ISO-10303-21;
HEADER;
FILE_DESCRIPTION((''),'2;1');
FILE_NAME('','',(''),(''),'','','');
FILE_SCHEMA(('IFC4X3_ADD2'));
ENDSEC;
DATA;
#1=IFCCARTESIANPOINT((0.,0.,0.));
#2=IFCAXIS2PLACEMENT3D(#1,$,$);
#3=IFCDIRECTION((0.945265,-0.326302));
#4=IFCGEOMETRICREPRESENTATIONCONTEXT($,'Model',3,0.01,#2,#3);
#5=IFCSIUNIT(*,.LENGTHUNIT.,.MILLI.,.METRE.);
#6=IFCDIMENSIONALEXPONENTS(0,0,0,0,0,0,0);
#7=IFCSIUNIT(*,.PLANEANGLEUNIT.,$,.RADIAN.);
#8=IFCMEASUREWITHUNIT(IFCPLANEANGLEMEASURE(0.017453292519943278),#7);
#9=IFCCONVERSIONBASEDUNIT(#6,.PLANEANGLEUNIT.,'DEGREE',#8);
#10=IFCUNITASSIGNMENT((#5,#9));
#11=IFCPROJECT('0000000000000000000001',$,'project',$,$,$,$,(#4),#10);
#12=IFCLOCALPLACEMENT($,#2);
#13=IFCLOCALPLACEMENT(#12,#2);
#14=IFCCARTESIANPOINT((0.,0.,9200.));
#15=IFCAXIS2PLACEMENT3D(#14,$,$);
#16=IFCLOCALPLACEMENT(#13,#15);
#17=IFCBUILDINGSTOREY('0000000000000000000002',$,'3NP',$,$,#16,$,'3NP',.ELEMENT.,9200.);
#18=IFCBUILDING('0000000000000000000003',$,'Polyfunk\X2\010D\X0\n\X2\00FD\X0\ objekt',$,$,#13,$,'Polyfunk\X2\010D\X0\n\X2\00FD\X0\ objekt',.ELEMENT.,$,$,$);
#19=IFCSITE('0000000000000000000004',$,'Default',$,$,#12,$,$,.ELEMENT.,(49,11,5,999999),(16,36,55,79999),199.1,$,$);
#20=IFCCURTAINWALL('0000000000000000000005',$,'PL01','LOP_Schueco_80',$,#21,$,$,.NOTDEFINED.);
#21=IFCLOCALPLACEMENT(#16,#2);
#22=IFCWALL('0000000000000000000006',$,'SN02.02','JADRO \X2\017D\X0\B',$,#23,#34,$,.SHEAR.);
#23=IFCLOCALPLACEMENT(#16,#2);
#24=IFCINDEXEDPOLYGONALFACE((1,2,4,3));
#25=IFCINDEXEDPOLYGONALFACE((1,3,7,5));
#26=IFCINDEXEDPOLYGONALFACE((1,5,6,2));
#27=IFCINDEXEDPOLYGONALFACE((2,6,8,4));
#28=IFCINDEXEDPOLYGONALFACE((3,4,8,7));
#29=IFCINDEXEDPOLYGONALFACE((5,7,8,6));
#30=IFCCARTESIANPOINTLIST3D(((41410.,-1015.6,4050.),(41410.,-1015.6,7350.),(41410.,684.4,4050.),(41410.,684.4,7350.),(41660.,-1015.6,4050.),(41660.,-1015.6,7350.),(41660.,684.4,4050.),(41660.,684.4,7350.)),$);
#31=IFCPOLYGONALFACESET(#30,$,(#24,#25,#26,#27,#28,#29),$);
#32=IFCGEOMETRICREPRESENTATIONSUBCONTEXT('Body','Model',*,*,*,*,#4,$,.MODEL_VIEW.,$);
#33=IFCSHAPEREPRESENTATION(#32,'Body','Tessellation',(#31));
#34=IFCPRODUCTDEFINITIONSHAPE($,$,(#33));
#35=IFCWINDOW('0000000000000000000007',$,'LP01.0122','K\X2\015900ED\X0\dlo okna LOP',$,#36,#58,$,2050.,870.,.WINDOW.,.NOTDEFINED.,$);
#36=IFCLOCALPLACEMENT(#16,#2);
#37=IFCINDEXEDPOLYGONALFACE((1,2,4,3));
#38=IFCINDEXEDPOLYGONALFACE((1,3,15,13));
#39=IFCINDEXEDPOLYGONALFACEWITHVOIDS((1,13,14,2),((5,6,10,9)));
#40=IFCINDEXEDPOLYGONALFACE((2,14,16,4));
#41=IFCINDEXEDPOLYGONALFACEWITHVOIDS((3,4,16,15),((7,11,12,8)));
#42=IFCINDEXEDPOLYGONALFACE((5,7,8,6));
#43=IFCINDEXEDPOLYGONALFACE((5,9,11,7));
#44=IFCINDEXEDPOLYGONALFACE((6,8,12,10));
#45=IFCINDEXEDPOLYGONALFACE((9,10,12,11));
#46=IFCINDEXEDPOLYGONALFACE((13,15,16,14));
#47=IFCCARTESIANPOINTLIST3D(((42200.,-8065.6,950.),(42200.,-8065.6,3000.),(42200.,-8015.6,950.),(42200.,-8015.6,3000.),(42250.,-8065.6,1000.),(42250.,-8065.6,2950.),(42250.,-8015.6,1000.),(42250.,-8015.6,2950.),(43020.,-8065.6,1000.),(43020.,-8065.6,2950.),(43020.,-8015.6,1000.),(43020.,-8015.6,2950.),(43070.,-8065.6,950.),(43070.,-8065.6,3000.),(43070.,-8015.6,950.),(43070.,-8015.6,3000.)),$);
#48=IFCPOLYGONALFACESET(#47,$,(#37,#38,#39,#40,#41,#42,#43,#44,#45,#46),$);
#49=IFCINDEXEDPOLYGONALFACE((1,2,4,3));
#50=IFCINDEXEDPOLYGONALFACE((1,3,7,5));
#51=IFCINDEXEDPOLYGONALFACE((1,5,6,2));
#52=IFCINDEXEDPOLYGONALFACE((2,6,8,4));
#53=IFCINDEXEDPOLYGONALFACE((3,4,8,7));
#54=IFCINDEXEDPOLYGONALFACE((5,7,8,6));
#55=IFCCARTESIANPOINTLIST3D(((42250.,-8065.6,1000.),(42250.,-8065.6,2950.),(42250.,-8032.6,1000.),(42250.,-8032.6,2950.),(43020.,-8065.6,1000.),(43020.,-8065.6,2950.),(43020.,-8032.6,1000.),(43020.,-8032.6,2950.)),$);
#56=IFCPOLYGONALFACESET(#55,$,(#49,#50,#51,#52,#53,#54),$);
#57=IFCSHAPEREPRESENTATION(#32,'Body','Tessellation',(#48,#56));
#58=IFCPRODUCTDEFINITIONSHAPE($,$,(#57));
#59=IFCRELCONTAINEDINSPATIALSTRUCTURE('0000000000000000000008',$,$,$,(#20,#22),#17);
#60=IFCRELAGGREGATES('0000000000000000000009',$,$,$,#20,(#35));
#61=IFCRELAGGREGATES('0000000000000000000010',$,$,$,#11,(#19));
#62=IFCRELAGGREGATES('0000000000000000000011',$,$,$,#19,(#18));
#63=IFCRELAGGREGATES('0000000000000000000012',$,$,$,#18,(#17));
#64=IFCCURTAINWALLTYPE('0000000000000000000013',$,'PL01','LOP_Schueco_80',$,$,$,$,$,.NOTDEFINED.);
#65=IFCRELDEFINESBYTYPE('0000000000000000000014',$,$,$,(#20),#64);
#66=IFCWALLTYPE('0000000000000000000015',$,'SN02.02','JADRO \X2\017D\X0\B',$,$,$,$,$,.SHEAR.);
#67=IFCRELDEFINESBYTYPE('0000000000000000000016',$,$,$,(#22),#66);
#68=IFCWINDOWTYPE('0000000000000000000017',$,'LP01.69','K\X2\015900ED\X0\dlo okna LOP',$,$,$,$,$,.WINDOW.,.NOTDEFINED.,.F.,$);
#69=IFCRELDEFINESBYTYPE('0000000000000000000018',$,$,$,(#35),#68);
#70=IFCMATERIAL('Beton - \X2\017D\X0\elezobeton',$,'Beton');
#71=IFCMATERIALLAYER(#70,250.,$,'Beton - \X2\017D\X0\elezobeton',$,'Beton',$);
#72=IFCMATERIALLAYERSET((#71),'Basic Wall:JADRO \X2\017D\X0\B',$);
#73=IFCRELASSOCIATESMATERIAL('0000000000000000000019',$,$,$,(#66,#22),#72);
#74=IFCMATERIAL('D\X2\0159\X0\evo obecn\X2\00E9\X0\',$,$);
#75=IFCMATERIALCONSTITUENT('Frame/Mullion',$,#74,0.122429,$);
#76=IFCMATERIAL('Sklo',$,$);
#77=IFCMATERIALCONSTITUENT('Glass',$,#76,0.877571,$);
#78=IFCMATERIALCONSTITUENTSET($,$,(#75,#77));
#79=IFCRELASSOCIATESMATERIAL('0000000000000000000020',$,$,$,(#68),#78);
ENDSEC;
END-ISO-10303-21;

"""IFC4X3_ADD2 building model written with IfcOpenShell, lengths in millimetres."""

from ifc_helpers import new_model, entity, si_unit, converted_unit, direction, frame, frame_2d, origin, place, context, subcontext, project, spatial, polyline, rectangle, outline, extrude, clip, bounded_halfspace, source, transform, mapped, material, layer, layer_set, constituent, constituent_set, type_object, type_shapes, element, aggregate, save


model = new_model("IFC4X3_ADD2")

# Units and contexts
model_context = context("Model", 3, precision=0.01, world=origin(), true_north=direction((0.945265, -0.326302)))
body_context = subcontext(model_context, "Body", "Model", "MODEL_VIEW")
ifc_project = project(units=[si_unit("LENGTHUNIT", "METRE", prefix="MILLI"), converted_unit("PLANEANGLEUNIT", "DEGREE", entity("IfcPlaneAngleMeasure", 0.017453292519943278), si_unit("PLANEANGLEUNIT", "RADIAN"), dimensions=[0, 0, 0, 0, 0, 0, 0])], contexts=[model_context])

# Site, building, storey
site_placement = place(None, origin())
site = spatial("IfcSite", under=ifc_project, at=site_placement, Name="Default", CompositionType="ELEMENT", RefLatitude=(49, 11, 5, 999999), RefLongitude=(16, 36, 55, 79999), RefElevation=199.1)
building_placement = place(site_placement, origin())
building = spatial("IfcBuilding", under=site, at=building_placement, Name="Polyfunkčný objekt", LongName="Polyfunkčný objekt", CompositionType="ELEMENT")
storey_placement = place(building_placement, frame((0.0, 0.0, 9200.0)))
storey = spatial("IfcBuildingStorey", under=building, at=storey_placement, Name="3NP", LongName="3NP", CompositionType="ELEMENT", Elevation=9200.0)

# Curtain wall
curtain_wall_type = type_object("IfcCurtainWallType", Name="PL01", Description="LOP_Schueco_80", PredefinedType="NOTDEFINED")
curtain_wall_placement = place(storey_placement, frame((0.0, 0.0, -9200.0)))
curtain_wall = element("IfcCurtainWall", 1, at=curtain_wall_placement, inside=storey, type_object=curtain_wall_type, Name="PL01", Description="LOP_Schueco_80", PredefinedType="NOTDEFINED")
ifc_material_1 = material(Name="Sklo")

# Wall
ifc_material_2 = material(Name="Beton - Železobeton", Category="Beton")
ifc_layer_1 = layer(ifc_material_2, 250.0, Name="Beton - Železobeton", Category="Beton")
ifc_layer_set_1 = layer_set([ifc_layer_1], Name="Basic Wall:JADRO ŽB")
wall_type = type_object("IfcWallType", Name="SN02.02", Description="JADRO ŽB", PredefinedType="SHEAR", material=ifc_layer_set_1)
wall_1_placement = place(storey_placement, frame((41535.0, 684.4, 4050.0), z_axis=(0.0, 0.0, 1.0), x_axis=(0.0, -1.0, 0.0)))
element("IfcWall", 2, at=wall_1_placement, inside=storey, type_object=wall_type, material=ifc_layer_set_1, Name="SN02.02", Description="JADRO ŽB", PredefinedType="SHEAR", context=body_context, shape_type="Clipping", body=[
    clip(clip(extrude(rectangle(XDim=1700.0, YDim=250.0, at=frame_2d((850.0, 0.0), x_axis=(-1.0, 0.0))), origin(), (0.0, 0.0, 1.0), 3300.0), bounded_halfspace(frame((1700.0, -125.0, 0.0), z_axis=(0.0, 0.0, 1.0), x_axis=(0.0, -1.0, 0.0)), True, frame((1700.0, -125.0, 0.0)), polyline([(0.0, 0.0), (0.0, 250.0), (-1700.0, 250.0), (-1700.0, 0.0), (0.0, 0.0)]))), bounded_halfspace(frame((0.0, -125.0, 3300.0), z_axis=(0.0, 0.0, -1.0), x_axis=(1.0, 0.0, 0.0)), True, frame((0.0, -125.0, 3300.0)), polyline([(0.0, 0.0), (1700.0, 0.0), (1700.0, 250.0), (0.0, 250.0), (0.0, 0.0)]))),
])

# Window
ifc_material_3 = material(Name="Dřevo obecné")
ifc_constituent_1 = constituent(ifc_material_3, Name="Frame/Mullion", fraction=0.122429)
ifc_constituent_2 = constituent(ifc_material_1, Name="Glass", fraction=0.877571)
ifc_constituent_set = constituent_set(constituents=[ifc_constituent_1, ifc_constituent_2])
window_type = type_object("IfcWindowType", Name="LP01.69", Description="Křídlo okna LOP", ParameterTakesPrecedence=False, PartitioningType="NOTDEFINED", PredefinedType="WINDOW", material=ifc_constituent_set)
shared_shape_1 = source(origin(), body_context, "Body", "SweptSolid", [
    extrude(outline(polyline([(-1025.0, -435.0), (1025.0, -435.0), (1025.0, 435.0), (-1025.0, 435.0), (-1025.0, -435.0)]), holes=[polyline([(-975.0, -385.0), (-975.0, 385.0), (975.0, 385.0), (975.0, -385.0), (-975.0, -385.0)])]), frame((0.0, 50.0, 1025.0), z_axis=(0.0, -1.0, 0.0), x_axis=(0.0, 0.0, -1.0)), (0.0, 0.0, 1.0), 50.0),
    extrude(rectangle(XDim=770.0, YDim=33.0, at=frame_2d((0.0, 0.0), x_axis=(1.0, 0.0))), frame((0.0, 33.5, 50.0), z_axis=(0.0, 0.0, 1.0), x_axis=(-1.0, 0.0, 0.0)), (0.0, 0.0, 1.0), 1950.0),
])
type_shapes(window_type, [shared_shape_1])
window_placement = place(curtain_wall_placement, frame((42635.0, -8015.6, 10150.0), z_axis=(0.0, 0.0, 1.0), x_axis=(-1.0, 0.0, 0.0)))
window = element("IfcWindow", 3, at=window_placement, type_object=window_type, Name="LP01.0122", Description="Křídlo okna LOP", OverallHeight=2050.0, OverallWidth=870.0, PartitioningType="NOTDEFINED", PredefinedType="WINDOW", context=body_context, shape_type="MappedRepresentation", body=[
    mapped(shared_shape_1, transform((0.0, 0.0, 0.0), scale=1.0)),
])
aggregate(curtain_wall, [window])

save(model, "model.ifc")
